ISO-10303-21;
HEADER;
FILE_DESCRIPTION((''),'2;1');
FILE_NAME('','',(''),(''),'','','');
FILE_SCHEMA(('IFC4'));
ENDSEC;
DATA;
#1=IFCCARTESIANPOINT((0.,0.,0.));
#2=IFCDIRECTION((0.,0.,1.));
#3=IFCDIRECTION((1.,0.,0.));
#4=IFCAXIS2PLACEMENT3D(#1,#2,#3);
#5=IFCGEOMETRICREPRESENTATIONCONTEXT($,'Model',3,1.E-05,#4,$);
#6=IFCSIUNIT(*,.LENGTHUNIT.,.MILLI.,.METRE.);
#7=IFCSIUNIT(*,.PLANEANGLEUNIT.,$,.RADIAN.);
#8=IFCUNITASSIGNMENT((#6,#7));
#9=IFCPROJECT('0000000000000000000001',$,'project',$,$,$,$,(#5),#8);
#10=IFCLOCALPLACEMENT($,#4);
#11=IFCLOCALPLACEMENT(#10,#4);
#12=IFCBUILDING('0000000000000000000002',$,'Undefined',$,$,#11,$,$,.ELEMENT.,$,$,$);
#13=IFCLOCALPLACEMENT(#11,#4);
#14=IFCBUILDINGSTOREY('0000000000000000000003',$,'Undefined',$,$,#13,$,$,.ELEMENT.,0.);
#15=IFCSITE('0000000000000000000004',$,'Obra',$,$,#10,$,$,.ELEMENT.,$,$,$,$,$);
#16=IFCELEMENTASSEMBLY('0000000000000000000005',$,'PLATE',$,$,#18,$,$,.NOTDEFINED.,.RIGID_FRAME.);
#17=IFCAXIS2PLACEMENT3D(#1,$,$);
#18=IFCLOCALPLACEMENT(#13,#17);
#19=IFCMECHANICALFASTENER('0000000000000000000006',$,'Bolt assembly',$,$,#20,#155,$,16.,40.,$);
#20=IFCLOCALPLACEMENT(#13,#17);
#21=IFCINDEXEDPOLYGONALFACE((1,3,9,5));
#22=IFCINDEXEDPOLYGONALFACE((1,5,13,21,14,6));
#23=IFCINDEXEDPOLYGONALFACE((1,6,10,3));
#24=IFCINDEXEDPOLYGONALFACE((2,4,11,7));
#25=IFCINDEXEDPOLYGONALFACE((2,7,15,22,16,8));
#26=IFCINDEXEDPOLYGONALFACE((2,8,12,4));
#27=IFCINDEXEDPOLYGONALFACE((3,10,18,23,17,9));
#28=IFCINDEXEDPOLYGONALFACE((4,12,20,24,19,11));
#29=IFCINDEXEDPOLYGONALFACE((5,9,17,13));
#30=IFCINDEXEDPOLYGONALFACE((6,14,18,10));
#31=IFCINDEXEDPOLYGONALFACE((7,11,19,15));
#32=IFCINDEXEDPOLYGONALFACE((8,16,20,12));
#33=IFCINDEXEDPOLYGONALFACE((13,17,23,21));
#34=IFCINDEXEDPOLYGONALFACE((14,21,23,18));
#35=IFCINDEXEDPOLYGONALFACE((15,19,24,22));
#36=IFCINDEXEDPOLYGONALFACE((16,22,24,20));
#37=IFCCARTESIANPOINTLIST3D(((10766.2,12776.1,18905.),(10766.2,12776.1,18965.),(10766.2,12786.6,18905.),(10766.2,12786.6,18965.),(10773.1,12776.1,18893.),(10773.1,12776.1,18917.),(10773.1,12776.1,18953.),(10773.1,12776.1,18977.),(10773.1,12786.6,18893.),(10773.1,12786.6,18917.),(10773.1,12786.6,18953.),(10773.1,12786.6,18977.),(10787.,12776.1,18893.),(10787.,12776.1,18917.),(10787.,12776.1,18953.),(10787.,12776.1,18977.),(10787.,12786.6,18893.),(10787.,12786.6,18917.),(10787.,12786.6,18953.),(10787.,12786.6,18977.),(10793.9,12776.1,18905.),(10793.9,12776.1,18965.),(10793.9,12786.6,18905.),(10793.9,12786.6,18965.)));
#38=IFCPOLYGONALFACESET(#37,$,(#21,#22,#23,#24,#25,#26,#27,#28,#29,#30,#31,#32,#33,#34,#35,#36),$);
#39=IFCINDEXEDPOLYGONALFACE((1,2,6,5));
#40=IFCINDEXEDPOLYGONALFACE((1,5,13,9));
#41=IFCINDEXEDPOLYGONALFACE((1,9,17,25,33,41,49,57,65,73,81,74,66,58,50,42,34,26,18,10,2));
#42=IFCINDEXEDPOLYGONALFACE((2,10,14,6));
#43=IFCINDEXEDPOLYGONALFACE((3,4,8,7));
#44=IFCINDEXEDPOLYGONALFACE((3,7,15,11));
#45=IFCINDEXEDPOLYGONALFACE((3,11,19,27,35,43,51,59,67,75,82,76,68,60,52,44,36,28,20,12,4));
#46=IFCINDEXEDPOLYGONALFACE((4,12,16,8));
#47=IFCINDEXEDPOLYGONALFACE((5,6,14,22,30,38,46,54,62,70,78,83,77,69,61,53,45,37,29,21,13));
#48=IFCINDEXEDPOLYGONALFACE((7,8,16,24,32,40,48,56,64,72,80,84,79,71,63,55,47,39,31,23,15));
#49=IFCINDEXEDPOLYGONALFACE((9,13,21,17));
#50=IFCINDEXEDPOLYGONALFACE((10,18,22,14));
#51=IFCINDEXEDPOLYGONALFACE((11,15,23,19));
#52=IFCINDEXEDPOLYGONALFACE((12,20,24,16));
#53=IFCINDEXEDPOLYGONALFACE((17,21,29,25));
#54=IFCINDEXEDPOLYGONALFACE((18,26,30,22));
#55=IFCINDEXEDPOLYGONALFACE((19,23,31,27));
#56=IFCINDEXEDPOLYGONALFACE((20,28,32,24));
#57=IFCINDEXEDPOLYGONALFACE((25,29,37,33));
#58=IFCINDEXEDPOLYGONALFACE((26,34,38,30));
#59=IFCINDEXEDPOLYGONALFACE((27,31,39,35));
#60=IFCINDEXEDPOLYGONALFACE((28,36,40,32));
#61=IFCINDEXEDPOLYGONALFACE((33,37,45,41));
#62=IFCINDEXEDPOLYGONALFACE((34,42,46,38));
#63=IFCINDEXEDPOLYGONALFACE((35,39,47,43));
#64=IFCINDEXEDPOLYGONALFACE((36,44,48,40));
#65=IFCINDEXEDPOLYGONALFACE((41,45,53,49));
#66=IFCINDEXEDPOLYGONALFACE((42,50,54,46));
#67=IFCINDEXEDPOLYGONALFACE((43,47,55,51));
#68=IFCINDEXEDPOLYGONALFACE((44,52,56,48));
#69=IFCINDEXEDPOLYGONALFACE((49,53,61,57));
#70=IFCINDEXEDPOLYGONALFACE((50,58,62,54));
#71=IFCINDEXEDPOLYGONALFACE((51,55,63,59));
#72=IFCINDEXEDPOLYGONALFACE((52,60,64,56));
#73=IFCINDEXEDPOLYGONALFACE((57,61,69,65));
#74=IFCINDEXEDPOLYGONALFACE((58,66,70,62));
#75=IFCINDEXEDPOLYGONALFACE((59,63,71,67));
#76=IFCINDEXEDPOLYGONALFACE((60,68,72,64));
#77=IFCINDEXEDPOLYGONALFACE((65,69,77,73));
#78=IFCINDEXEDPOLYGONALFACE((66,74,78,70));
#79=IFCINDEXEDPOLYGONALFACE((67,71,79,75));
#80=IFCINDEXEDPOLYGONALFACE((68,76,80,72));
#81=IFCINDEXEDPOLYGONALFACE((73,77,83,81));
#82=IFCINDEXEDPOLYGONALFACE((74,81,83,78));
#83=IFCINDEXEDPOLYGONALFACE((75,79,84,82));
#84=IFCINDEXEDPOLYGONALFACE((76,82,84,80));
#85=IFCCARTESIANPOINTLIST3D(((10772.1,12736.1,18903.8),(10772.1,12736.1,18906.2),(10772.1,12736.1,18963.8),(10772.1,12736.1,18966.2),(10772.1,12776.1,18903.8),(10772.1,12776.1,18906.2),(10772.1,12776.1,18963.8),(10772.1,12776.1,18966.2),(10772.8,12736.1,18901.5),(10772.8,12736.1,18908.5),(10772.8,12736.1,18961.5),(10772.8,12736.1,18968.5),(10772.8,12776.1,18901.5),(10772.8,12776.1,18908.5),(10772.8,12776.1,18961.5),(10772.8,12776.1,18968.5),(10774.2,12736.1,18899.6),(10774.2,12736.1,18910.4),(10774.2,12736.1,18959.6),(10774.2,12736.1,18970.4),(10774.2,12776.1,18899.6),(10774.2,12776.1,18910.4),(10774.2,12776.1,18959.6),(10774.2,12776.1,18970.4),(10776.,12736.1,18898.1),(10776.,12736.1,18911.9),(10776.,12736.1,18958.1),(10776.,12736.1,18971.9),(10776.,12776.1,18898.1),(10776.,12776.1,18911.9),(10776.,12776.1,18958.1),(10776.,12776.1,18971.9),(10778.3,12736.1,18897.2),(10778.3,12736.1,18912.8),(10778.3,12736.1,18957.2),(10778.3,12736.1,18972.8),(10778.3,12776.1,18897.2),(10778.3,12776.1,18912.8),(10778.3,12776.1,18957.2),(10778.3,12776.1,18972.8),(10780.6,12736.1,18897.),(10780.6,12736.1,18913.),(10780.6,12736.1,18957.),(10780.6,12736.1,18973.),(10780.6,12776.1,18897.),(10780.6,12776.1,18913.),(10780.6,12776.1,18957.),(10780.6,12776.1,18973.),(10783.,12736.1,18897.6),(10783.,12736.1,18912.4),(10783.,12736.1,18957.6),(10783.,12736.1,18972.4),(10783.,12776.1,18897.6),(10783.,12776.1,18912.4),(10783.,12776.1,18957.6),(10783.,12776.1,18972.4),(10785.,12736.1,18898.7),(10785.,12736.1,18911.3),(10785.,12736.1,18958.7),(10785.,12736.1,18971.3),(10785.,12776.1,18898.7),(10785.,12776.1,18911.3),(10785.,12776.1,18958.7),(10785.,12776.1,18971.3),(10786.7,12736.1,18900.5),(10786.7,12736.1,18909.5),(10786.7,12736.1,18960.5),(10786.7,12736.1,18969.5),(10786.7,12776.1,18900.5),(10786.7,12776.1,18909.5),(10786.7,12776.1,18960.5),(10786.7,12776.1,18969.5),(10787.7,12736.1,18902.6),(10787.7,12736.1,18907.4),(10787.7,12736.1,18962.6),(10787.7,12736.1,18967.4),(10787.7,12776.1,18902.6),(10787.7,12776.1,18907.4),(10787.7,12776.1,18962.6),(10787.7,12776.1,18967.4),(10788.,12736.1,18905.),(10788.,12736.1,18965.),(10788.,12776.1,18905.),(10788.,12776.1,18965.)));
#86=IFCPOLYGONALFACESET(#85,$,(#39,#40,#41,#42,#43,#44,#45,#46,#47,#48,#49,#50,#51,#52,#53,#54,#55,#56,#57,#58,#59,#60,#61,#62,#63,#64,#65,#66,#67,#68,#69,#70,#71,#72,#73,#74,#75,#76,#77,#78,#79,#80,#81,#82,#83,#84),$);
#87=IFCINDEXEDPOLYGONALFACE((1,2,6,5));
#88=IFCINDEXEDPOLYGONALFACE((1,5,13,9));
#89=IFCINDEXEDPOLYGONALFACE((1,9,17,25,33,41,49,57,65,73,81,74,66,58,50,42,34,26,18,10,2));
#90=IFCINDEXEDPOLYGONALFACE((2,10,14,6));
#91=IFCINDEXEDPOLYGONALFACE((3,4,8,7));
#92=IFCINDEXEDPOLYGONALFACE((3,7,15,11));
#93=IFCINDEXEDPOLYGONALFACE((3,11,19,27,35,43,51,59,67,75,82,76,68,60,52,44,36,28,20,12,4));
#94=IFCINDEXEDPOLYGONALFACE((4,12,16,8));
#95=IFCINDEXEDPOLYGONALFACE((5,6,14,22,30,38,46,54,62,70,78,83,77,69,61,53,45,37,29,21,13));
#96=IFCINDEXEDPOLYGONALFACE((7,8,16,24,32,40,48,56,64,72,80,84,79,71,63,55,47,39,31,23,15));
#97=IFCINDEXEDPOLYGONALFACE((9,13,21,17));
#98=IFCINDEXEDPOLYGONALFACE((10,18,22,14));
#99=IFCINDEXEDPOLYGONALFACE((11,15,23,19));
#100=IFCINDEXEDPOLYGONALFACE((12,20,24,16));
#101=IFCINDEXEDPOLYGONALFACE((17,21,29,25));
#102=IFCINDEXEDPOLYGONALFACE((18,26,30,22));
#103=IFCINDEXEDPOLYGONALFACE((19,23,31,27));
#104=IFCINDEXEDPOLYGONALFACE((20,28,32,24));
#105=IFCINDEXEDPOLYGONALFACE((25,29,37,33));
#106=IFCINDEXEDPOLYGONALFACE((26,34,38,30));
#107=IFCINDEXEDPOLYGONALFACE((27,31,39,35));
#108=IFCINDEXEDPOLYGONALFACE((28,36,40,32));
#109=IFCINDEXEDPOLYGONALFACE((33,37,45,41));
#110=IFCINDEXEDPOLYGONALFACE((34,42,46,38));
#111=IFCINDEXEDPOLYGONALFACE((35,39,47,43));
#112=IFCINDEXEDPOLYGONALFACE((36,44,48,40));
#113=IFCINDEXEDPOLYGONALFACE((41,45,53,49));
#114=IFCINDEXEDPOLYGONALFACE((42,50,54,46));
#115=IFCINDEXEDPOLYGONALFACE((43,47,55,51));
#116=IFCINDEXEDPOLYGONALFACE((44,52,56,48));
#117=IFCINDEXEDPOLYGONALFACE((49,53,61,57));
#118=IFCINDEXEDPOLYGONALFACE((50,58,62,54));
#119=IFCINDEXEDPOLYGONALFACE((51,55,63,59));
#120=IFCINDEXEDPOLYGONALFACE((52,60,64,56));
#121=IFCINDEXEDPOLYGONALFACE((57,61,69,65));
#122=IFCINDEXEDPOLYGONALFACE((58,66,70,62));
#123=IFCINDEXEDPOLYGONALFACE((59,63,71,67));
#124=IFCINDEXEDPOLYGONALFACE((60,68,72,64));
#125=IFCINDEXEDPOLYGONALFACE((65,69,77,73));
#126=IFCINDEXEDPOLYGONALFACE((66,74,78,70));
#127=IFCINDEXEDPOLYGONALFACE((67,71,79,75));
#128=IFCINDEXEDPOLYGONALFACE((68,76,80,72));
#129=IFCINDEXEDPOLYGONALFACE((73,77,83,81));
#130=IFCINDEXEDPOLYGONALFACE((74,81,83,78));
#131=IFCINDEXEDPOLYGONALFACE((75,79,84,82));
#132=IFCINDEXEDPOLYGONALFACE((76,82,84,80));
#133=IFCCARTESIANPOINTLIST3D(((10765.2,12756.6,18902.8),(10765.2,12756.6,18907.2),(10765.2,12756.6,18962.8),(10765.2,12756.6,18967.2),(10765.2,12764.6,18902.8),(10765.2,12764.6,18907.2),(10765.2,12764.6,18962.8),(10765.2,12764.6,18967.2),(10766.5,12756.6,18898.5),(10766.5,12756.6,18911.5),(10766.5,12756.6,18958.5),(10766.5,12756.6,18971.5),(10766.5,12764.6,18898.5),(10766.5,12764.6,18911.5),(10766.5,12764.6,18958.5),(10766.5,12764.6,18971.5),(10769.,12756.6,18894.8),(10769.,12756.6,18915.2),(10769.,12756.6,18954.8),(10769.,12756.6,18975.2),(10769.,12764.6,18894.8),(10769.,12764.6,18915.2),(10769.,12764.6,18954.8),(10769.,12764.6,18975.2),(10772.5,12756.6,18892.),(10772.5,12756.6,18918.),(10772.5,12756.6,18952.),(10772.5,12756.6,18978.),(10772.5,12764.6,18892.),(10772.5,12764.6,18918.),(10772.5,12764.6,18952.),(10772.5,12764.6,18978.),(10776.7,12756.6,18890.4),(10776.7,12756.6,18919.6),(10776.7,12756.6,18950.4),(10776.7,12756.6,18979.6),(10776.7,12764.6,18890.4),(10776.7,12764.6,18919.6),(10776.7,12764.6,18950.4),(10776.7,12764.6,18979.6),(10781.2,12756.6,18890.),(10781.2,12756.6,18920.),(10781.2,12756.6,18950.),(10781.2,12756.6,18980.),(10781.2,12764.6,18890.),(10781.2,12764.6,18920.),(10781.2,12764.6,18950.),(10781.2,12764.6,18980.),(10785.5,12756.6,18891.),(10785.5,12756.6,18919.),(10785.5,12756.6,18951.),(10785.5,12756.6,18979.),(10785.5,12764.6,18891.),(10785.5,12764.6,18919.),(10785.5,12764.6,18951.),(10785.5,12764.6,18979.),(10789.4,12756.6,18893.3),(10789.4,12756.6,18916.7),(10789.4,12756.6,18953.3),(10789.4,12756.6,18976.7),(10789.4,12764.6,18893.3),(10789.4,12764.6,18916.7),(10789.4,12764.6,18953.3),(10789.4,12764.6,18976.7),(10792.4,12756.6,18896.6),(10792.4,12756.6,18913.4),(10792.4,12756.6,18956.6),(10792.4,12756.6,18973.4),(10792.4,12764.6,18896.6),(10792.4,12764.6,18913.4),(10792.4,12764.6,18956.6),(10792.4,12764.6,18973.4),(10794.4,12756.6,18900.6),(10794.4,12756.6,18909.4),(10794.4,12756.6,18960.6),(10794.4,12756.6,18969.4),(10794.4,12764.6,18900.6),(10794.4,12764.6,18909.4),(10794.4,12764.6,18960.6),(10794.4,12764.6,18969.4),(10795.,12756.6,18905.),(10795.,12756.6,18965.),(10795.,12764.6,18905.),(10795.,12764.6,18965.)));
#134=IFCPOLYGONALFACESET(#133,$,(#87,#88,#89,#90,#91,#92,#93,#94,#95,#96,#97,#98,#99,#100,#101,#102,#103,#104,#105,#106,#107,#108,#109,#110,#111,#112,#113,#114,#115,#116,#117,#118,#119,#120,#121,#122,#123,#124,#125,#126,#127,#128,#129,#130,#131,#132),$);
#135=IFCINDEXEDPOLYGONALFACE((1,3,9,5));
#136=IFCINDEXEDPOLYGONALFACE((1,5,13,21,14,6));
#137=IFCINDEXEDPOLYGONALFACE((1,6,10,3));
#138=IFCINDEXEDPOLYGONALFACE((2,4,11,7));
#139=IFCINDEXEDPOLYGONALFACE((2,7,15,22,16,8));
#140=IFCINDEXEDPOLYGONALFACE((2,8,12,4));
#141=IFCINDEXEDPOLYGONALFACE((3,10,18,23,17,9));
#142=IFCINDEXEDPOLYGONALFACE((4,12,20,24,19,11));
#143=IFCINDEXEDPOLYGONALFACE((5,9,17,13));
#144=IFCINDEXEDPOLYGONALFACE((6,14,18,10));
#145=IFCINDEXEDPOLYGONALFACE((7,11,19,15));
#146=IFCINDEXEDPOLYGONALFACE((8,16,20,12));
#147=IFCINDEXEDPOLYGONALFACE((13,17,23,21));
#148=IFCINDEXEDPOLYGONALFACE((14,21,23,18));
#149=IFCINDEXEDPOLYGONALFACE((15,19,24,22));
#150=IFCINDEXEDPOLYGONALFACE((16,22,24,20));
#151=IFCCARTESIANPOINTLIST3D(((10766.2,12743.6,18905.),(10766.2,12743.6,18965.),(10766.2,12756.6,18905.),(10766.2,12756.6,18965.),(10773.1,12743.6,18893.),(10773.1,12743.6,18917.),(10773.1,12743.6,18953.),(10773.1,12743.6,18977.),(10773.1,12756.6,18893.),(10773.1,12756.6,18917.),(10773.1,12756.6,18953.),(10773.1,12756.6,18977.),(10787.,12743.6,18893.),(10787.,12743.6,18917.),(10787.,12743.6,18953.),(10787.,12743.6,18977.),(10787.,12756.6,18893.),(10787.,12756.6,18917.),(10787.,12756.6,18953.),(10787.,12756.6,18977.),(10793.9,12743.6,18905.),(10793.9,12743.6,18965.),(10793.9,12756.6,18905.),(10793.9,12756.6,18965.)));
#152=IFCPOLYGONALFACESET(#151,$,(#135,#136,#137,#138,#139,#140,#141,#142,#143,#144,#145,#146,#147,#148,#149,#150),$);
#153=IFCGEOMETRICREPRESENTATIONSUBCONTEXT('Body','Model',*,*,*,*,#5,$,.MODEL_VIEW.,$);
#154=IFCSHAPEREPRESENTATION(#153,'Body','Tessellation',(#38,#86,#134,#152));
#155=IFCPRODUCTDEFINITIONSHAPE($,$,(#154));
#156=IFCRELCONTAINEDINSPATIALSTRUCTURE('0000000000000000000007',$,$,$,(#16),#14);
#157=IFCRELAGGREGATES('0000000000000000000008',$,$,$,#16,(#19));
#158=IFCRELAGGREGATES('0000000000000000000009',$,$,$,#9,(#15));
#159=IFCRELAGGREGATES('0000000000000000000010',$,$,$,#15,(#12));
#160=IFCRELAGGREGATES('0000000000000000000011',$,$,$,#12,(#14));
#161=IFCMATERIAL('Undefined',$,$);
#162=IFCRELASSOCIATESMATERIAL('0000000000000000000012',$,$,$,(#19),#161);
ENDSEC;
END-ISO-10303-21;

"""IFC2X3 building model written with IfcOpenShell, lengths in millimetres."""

from ifc_helpers import new_model, si_unit, frame, origin_with_axes, origin_2d_with_axis, place, context, subcontext, project, spatial, polyline, circle, outline, extrude, source, transform, mapped, material, element, aggregate, save


model = new_model("IFC2X3")

# Units and contexts
model_context = context("Model", 3, precision=1e-05, world=origin_with_axes())
body_context = subcontext(model_context, "Body", "Model", "MODEL_VIEW")
ifc_project = project(units=[si_unit("LENGTHUNIT", "METRE", prefix="MILLI"), si_unit("PLANEANGLEUNIT", "RADIAN")], contexts=[model_context])

# Site, building, storey
site_placement = place(None, origin_with_axes())
site = spatial("IfcSite", under=ifc_project, at=site_placement, Name="Obra", CompositionType="ELEMENT")
building_placement = place(site_placement, origin_with_axes())
building = spatial("IfcBuilding", under=site, at=building_placement, Name="Undefined", CompositionType="ELEMENT")
storey_placement = place(building_placement, origin_with_axes())
storey = spatial("IfcBuildingStorey", under=building, at=storey_placement, Name="Undefined", CompositionType="ELEMENT", Elevation=0.0)

# Element assembly
assembly_1_placement = place(storey_placement, origin_with_axes())
assembly_1 = element("IfcElementAssembly", 1, at=assembly_1_placement, inside=storey, Name="PLATE", AssemblyPlace="NOTDEFINED", PredefinedType="RIGID_FRAME")

# Mechanical fastener
ifc_material_1 = material(Name="Undefined")
shared_shape_1 = source(origin_with_axes(), body_context, "Body", "SweptSolid", [
    extrude(outline(polyline([(13.9, 0.0), (6.9, 12.0), (-6.9, 12.0), (-13.9, 0.0), (-6.9, -12.0), (6.9, -12.0), (13.9, 0.0)])), frame((0.0, -16.6, 0.0), z_axis=(0.0, 1.0, 0.0), x_axis=(1.0, 0.0, 0.0)), (0.0, 0.0, 1.0), 10.6),
    extrude(circle(Radius=8.0, at=origin_2d_with_axis()), frame((0.0, -6.0, 0.0), z_axis=(0.0, 1.0, 0.0), x_axis=(1.0, 0.0, 0.0)), (0.0, 0.0, 1.0), 40.0),
    extrude(circle(Radius=15.0, at=origin_2d_with_axis()), frame((0.0, 5.5, 0.0), z_axis=(0.0, 1.0, 0.0), x_axis=(1.0, 0.0, 0.0)), (0.0, 0.0, 1.0), 8.0),
    extrude(outline(polyline([(13.9, 0.0), (6.9, 12.0), (-6.9, 12.0), (-13.9, 0.0), (-6.9, -12.0), (6.9, -12.0), (13.9, 0.0)])), frame((0.0, 13.5, 0.0), z_axis=(0.0, 1.0, 0.0), x_axis=(1.0, 0.0, 0.0)), (0.0, 0.0, 1.0), 13.0),
])
mechanical_fastener_1_placement = place(assembly_1_placement, frame((10780.0, 12770.1, 18935.0), z_axis=(0.0, 0.0, -1.0), x_axis=(1.0, 0.0, 0.0)))
mechanical_fastener_1 = element("IfcMechanicalFastener", 2, at=mechanical_fastener_1_placement, material=ifc_material_1, Name="Bolt assembly", NominalDiameter=16.0, NominalLength=40.0, context=body_context, shape_type="MappedRepresentation", body=[
    mapped(shared_shape_1, transform((0.0, 0.0, 30.0))),
    mapped(shared_shape_1, transform((0.0, 0.0, -30.0))),
])
aggregate(assembly_1, [mechanical_fastener_1])

save(model, "model.ifc")
